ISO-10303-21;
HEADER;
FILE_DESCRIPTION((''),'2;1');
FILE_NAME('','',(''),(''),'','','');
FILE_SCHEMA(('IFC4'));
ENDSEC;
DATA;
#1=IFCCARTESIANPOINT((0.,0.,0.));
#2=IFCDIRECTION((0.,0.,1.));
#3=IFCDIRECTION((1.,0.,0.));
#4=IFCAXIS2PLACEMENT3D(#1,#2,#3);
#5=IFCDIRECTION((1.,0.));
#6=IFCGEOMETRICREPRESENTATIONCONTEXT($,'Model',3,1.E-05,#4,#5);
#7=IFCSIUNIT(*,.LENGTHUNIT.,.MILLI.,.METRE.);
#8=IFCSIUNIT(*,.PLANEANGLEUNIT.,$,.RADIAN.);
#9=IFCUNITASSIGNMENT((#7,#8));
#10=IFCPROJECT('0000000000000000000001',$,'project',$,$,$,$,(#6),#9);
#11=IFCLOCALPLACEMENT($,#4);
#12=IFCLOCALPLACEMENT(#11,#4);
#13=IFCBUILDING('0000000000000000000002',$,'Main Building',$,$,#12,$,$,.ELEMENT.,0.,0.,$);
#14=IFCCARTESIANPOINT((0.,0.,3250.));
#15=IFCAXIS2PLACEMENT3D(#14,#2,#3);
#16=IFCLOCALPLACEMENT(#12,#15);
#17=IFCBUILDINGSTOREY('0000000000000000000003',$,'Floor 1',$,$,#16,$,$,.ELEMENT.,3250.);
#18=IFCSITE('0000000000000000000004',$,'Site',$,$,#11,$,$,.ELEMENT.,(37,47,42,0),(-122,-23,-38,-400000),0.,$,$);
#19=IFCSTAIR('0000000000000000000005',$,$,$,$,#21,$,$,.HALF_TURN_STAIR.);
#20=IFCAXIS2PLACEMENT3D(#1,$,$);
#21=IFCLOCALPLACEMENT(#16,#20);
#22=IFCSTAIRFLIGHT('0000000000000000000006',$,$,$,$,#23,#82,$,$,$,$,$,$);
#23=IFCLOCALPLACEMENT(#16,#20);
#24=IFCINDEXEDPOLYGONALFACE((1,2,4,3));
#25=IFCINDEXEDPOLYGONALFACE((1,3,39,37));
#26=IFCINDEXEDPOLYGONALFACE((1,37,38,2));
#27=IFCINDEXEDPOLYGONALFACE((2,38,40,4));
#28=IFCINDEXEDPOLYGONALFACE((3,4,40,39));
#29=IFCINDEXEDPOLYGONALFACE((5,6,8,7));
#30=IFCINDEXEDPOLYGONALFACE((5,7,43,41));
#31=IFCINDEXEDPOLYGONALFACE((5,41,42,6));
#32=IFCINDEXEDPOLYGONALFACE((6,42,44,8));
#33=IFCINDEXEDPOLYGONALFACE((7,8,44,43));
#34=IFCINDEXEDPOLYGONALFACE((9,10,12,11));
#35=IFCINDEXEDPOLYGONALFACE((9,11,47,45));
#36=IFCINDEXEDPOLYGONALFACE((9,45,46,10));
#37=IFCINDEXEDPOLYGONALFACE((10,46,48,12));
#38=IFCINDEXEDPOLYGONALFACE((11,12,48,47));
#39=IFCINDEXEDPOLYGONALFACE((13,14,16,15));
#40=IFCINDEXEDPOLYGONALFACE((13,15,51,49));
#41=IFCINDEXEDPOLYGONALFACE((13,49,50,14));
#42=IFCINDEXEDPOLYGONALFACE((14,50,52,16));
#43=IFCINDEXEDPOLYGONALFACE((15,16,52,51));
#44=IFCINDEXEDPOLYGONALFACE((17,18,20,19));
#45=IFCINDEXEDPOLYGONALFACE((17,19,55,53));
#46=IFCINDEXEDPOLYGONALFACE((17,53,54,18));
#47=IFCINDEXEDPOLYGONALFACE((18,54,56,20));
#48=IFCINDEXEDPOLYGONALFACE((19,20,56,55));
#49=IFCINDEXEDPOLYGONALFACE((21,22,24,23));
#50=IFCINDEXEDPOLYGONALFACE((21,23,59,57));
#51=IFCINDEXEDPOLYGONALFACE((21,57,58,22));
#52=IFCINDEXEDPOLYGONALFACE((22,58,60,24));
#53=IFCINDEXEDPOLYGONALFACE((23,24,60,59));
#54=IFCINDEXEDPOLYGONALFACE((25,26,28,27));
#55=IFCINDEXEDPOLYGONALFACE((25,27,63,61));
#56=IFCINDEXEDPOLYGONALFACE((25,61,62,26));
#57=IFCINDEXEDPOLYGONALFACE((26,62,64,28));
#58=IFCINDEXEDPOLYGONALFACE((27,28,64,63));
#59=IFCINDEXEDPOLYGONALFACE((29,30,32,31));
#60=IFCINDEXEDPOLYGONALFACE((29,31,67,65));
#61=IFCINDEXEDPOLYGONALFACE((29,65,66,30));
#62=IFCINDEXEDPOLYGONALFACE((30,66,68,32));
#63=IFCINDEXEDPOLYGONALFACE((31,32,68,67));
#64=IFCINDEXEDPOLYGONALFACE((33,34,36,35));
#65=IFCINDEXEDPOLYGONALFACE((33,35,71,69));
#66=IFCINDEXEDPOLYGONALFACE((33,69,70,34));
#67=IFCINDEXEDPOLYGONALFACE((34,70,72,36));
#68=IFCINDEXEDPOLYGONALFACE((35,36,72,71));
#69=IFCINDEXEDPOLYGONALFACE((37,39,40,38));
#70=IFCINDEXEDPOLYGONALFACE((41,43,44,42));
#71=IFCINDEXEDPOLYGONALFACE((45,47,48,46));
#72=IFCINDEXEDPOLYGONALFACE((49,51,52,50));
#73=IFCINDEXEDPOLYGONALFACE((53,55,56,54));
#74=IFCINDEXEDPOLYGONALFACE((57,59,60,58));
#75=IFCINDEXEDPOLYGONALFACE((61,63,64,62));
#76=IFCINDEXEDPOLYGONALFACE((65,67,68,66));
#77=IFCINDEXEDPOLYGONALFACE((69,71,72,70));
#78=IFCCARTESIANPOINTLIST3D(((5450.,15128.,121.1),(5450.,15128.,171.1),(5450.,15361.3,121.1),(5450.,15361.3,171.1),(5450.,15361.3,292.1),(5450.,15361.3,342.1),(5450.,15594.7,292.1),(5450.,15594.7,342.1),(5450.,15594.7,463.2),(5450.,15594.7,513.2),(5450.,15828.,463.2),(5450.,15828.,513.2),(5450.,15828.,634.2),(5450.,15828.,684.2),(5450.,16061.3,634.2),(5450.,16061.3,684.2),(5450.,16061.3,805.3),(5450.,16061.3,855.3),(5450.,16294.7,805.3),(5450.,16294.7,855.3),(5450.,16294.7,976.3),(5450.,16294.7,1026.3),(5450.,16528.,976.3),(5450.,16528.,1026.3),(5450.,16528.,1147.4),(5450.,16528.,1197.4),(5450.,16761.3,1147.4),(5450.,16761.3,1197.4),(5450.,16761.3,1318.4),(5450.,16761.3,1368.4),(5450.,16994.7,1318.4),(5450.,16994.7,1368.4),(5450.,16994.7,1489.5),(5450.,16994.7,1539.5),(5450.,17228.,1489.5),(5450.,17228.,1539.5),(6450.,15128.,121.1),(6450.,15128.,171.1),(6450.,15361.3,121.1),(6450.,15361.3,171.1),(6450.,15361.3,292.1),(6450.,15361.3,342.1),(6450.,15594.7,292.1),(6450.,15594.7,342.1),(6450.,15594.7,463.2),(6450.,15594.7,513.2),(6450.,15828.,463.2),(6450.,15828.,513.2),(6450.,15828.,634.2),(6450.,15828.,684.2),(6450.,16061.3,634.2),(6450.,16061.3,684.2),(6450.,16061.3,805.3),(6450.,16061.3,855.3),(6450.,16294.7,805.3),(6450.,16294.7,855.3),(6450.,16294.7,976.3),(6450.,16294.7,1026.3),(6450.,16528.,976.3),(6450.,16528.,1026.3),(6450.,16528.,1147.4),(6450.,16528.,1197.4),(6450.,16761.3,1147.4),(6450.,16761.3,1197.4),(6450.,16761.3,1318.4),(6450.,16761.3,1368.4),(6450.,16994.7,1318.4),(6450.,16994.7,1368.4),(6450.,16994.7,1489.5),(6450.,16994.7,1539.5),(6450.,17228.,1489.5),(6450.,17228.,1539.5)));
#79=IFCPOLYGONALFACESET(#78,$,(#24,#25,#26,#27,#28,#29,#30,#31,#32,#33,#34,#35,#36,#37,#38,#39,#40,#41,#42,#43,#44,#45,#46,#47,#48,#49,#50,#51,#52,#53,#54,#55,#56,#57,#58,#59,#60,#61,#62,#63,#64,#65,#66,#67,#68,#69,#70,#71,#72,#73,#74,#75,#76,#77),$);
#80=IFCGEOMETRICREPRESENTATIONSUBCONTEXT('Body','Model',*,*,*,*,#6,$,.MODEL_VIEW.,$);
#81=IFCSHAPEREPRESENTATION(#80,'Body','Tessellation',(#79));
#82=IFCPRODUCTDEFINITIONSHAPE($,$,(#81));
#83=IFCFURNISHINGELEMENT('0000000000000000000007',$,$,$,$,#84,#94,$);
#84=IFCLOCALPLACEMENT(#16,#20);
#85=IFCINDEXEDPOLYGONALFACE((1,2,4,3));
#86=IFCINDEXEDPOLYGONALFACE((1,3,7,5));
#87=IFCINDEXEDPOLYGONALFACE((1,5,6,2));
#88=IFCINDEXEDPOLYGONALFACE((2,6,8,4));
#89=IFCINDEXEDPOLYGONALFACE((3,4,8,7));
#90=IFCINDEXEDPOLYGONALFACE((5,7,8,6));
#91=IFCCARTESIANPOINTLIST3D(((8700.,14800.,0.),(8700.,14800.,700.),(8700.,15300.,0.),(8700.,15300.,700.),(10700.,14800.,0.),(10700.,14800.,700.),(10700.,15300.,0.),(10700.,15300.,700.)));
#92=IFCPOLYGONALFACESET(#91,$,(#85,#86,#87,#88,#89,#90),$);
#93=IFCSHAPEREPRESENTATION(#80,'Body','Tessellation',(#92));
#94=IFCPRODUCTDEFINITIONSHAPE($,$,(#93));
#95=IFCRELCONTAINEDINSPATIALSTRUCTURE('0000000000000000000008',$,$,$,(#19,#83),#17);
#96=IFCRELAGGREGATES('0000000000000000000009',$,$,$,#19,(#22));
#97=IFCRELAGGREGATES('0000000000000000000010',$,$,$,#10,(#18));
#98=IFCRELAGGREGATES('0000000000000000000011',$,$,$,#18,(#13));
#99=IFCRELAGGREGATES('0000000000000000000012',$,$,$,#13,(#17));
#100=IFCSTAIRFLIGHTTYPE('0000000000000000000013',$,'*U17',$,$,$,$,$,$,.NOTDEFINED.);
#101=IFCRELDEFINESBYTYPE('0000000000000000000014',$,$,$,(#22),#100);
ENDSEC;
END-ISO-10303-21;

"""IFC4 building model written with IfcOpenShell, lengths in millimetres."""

from ifc_helpers import new_model, si_unit, direction, frame, frame_2d, origin_with_axes, origin_2d_with_axis, place, context, subcontext, project, spatial, rectangle, extrude, source, transform, mapped, type_object, type_shapes, element, aggregate, save


model = new_model("IFC4")

# Units and contexts
model_context = context("Model", 3, precision=1e-05, world=origin_with_axes(), true_north=direction((1.0, 0.0)))
body_context = subcontext(model_context, "Body", "Model", "MODEL_VIEW")
ifc_project = project(units=[si_unit("LENGTHUNIT", "METRE", prefix="MILLI"), si_unit("PLANEANGLEUNIT", "RADIAN")], contexts=[model_context])

# Site, building, storey
site_placement = place(None, origin_with_axes())
site = spatial("IfcSite", under=ifc_project, at=site_placement, Name="Site", CompositionType="ELEMENT", RefLatitude=(37, 47, 42, 0), RefLongitude=(-122, -23, -38, -400000), RefElevation=0.0)
building_placement = place(site_placement, origin_with_axes())
building = spatial("IfcBuilding", under=site, at=building_placement, Name="Main Building", CompositionType="ELEMENT", ElevationOfRefHeight=0.0, ElevationOfTerrain=0.0)
storey_placement = place(building_placement, frame((0.0, 0.0, 3250.0), z_axis=(0.0, 0.0, 1.0), x_axis=(1.0, 0.0, 0.0)))
storey = spatial("IfcBuildingStorey", under=building, at=storey_placement, Name="Floor 1", CompositionType="ELEMENT", Elevation=3250.0)

# Stair, stair flight
stair_placement = place(storey_placement, frame((8550.0, 15128.0, 3250.0), z_axis=(0.0, 0.0, 1.0), x_axis=(0.0, 1.0, 0.0)))
stair = element("IfcStair", 1, at=stair_placement, inside=storey, PredefinedType="HALF_TURN_STAIR")
stair_flight_type_1 = type_object("IfcStairFlightType", Name="*U17", PredefinedType="NOTDEFINED")
shared_shape_1 = source(origin_with_axes(), body_context, "Body", "SweptSolid", [
    extrude(rectangle(XDim=1000.0, YDim=233.3, at=frame_2d((0.0, 0.0), x_axis=(0.0, 1.0))), frame((1983.3, 2600.0, -1760.5), z_axis=(0.0, 0.0, 1.0), x_axis=(1.0, 0.0, 0.0)), (0.0, 0.0, 1.0), 50.0),
])
shared_shape_2 = source(origin_with_axes(), body_context, "Body", "MappedRepresentation", [
    mapped(shared_shape_1, transform((0.0, 0.0, 0.0), x_axis=(1.0, 0.0, 0.0), y_axis=(0.0, 1.0, 0.0), z_axis=(0.0, 0.0, 1.0), scale=1.0)),
    mapped(shared_shape_1, transform((-233.3, 0.0, -171.1), x_axis=(1.0, 0.0, 0.0), y_axis=(0.0, 1.0, 0.0), z_axis=(0.0, 0.0, 1.0), scale=1.0)),
    mapped(shared_shape_1, transform((-466.7, 0.0, -342.1), x_axis=(1.0, 0.0, 0.0), y_axis=(0.0, 1.0, 0.0), z_axis=(0.0, 0.0, 1.0), scale=1.0)),
    mapped(shared_shape_1, transform((-700.0, 0.0, -513.2), x_axis=(1.0, 0.0, 0.0), y_axis=(0.0, 1.0, 0.0), z_axis=(0.0, 0.0, 1.0), scale=1.0)),
    mapped(shared_shape_1, transform((-933.3, 0.0, -684.2), x_axis=(1.0, 0.0, 0.0), y_axis=(0.0, 1.0, 0.0), z_axis=(0.0, 0.0, 1.0), scale=1.0)),
    mapped(shared_shape_1, transform((-1166.7, 0.0, -855.3), x_axis=(1.0, 0.0, 0.0), y_axis=(0.0, 1.0, 0.0), z_axis=(0.0, 0.0, 1.0), scale=1.0)),
    mapped(shared_shape_1, transform((-1400.0, 0.0, -1026.3), x_axis=(1.0, 0.0, 0.0), y_axis=(0.0, 1.0, 0.0), z_axis=(0.0, 0.0, 1.0), scale=1.0)),
    mapped(shared_shape_1, transform((-1633.3, 0.0, -1197.4), x_axis=(1.0, 0.0, 0.0), y_axis=(0.0, 1.0, 0.0), z_axis=(0.0, 0.0, 1.0), scale=1.0)),
    mapped(shared_shape_1, transform((-1866.7, 0.0, -1368.4), x_axis=(1.0, 0.0, 0.0), y_axis=(0.0, 1.0, 0.0), z_axis=(0.0, 0.0, 1.0), scale=1.0)),
])
type_shapes(stair_flight_type_1, [shared_shape_2])
stair_flight_1_placement = place(stair_placement, origin_with_axes())
stair_flight_1 = element("IfcStairFlight", 2, at=stair_flight_1_placement, type_object=stair_flight_type_1, context=body_context, shape_type="MappedRepresentation", body=[
    mapped(shared_shape_2, transform((0.0, 0.0, 0.0), x_axis=(1.0, 0.0, 0.0), y_axis=(0.0, 1.0, 0.0), z_axis=(0.0, 0.0, 1.0), scale=1.0)),
])

# Furnishing element
furnishing_placement = place(storey_placement, frame((8700.0, 14800.0, 0.0), z_axis=(0.0, 0.0, 1.0), x_axis=(1.0, 0.0, 0.0)))
element("IfcFurnishingElement", 3, at=furnishing_placement, inside=storey, context=body_context, shape_type="SweptSolid", body=[
    extrude(rectangle(XDim=2000.0, YDim=500.0, at=origin_2d_with_axis()), frame((1000.0, 250.0, 0.0), z_axis=(0.0, 0.0, 1.0), x_axis=(1.0, 0.0, 0.0)), (0.0, 0.0, 1.0), 700.0),
])

aggregate(stair, [stair_flight_1])

save(model, "model.ifc")
